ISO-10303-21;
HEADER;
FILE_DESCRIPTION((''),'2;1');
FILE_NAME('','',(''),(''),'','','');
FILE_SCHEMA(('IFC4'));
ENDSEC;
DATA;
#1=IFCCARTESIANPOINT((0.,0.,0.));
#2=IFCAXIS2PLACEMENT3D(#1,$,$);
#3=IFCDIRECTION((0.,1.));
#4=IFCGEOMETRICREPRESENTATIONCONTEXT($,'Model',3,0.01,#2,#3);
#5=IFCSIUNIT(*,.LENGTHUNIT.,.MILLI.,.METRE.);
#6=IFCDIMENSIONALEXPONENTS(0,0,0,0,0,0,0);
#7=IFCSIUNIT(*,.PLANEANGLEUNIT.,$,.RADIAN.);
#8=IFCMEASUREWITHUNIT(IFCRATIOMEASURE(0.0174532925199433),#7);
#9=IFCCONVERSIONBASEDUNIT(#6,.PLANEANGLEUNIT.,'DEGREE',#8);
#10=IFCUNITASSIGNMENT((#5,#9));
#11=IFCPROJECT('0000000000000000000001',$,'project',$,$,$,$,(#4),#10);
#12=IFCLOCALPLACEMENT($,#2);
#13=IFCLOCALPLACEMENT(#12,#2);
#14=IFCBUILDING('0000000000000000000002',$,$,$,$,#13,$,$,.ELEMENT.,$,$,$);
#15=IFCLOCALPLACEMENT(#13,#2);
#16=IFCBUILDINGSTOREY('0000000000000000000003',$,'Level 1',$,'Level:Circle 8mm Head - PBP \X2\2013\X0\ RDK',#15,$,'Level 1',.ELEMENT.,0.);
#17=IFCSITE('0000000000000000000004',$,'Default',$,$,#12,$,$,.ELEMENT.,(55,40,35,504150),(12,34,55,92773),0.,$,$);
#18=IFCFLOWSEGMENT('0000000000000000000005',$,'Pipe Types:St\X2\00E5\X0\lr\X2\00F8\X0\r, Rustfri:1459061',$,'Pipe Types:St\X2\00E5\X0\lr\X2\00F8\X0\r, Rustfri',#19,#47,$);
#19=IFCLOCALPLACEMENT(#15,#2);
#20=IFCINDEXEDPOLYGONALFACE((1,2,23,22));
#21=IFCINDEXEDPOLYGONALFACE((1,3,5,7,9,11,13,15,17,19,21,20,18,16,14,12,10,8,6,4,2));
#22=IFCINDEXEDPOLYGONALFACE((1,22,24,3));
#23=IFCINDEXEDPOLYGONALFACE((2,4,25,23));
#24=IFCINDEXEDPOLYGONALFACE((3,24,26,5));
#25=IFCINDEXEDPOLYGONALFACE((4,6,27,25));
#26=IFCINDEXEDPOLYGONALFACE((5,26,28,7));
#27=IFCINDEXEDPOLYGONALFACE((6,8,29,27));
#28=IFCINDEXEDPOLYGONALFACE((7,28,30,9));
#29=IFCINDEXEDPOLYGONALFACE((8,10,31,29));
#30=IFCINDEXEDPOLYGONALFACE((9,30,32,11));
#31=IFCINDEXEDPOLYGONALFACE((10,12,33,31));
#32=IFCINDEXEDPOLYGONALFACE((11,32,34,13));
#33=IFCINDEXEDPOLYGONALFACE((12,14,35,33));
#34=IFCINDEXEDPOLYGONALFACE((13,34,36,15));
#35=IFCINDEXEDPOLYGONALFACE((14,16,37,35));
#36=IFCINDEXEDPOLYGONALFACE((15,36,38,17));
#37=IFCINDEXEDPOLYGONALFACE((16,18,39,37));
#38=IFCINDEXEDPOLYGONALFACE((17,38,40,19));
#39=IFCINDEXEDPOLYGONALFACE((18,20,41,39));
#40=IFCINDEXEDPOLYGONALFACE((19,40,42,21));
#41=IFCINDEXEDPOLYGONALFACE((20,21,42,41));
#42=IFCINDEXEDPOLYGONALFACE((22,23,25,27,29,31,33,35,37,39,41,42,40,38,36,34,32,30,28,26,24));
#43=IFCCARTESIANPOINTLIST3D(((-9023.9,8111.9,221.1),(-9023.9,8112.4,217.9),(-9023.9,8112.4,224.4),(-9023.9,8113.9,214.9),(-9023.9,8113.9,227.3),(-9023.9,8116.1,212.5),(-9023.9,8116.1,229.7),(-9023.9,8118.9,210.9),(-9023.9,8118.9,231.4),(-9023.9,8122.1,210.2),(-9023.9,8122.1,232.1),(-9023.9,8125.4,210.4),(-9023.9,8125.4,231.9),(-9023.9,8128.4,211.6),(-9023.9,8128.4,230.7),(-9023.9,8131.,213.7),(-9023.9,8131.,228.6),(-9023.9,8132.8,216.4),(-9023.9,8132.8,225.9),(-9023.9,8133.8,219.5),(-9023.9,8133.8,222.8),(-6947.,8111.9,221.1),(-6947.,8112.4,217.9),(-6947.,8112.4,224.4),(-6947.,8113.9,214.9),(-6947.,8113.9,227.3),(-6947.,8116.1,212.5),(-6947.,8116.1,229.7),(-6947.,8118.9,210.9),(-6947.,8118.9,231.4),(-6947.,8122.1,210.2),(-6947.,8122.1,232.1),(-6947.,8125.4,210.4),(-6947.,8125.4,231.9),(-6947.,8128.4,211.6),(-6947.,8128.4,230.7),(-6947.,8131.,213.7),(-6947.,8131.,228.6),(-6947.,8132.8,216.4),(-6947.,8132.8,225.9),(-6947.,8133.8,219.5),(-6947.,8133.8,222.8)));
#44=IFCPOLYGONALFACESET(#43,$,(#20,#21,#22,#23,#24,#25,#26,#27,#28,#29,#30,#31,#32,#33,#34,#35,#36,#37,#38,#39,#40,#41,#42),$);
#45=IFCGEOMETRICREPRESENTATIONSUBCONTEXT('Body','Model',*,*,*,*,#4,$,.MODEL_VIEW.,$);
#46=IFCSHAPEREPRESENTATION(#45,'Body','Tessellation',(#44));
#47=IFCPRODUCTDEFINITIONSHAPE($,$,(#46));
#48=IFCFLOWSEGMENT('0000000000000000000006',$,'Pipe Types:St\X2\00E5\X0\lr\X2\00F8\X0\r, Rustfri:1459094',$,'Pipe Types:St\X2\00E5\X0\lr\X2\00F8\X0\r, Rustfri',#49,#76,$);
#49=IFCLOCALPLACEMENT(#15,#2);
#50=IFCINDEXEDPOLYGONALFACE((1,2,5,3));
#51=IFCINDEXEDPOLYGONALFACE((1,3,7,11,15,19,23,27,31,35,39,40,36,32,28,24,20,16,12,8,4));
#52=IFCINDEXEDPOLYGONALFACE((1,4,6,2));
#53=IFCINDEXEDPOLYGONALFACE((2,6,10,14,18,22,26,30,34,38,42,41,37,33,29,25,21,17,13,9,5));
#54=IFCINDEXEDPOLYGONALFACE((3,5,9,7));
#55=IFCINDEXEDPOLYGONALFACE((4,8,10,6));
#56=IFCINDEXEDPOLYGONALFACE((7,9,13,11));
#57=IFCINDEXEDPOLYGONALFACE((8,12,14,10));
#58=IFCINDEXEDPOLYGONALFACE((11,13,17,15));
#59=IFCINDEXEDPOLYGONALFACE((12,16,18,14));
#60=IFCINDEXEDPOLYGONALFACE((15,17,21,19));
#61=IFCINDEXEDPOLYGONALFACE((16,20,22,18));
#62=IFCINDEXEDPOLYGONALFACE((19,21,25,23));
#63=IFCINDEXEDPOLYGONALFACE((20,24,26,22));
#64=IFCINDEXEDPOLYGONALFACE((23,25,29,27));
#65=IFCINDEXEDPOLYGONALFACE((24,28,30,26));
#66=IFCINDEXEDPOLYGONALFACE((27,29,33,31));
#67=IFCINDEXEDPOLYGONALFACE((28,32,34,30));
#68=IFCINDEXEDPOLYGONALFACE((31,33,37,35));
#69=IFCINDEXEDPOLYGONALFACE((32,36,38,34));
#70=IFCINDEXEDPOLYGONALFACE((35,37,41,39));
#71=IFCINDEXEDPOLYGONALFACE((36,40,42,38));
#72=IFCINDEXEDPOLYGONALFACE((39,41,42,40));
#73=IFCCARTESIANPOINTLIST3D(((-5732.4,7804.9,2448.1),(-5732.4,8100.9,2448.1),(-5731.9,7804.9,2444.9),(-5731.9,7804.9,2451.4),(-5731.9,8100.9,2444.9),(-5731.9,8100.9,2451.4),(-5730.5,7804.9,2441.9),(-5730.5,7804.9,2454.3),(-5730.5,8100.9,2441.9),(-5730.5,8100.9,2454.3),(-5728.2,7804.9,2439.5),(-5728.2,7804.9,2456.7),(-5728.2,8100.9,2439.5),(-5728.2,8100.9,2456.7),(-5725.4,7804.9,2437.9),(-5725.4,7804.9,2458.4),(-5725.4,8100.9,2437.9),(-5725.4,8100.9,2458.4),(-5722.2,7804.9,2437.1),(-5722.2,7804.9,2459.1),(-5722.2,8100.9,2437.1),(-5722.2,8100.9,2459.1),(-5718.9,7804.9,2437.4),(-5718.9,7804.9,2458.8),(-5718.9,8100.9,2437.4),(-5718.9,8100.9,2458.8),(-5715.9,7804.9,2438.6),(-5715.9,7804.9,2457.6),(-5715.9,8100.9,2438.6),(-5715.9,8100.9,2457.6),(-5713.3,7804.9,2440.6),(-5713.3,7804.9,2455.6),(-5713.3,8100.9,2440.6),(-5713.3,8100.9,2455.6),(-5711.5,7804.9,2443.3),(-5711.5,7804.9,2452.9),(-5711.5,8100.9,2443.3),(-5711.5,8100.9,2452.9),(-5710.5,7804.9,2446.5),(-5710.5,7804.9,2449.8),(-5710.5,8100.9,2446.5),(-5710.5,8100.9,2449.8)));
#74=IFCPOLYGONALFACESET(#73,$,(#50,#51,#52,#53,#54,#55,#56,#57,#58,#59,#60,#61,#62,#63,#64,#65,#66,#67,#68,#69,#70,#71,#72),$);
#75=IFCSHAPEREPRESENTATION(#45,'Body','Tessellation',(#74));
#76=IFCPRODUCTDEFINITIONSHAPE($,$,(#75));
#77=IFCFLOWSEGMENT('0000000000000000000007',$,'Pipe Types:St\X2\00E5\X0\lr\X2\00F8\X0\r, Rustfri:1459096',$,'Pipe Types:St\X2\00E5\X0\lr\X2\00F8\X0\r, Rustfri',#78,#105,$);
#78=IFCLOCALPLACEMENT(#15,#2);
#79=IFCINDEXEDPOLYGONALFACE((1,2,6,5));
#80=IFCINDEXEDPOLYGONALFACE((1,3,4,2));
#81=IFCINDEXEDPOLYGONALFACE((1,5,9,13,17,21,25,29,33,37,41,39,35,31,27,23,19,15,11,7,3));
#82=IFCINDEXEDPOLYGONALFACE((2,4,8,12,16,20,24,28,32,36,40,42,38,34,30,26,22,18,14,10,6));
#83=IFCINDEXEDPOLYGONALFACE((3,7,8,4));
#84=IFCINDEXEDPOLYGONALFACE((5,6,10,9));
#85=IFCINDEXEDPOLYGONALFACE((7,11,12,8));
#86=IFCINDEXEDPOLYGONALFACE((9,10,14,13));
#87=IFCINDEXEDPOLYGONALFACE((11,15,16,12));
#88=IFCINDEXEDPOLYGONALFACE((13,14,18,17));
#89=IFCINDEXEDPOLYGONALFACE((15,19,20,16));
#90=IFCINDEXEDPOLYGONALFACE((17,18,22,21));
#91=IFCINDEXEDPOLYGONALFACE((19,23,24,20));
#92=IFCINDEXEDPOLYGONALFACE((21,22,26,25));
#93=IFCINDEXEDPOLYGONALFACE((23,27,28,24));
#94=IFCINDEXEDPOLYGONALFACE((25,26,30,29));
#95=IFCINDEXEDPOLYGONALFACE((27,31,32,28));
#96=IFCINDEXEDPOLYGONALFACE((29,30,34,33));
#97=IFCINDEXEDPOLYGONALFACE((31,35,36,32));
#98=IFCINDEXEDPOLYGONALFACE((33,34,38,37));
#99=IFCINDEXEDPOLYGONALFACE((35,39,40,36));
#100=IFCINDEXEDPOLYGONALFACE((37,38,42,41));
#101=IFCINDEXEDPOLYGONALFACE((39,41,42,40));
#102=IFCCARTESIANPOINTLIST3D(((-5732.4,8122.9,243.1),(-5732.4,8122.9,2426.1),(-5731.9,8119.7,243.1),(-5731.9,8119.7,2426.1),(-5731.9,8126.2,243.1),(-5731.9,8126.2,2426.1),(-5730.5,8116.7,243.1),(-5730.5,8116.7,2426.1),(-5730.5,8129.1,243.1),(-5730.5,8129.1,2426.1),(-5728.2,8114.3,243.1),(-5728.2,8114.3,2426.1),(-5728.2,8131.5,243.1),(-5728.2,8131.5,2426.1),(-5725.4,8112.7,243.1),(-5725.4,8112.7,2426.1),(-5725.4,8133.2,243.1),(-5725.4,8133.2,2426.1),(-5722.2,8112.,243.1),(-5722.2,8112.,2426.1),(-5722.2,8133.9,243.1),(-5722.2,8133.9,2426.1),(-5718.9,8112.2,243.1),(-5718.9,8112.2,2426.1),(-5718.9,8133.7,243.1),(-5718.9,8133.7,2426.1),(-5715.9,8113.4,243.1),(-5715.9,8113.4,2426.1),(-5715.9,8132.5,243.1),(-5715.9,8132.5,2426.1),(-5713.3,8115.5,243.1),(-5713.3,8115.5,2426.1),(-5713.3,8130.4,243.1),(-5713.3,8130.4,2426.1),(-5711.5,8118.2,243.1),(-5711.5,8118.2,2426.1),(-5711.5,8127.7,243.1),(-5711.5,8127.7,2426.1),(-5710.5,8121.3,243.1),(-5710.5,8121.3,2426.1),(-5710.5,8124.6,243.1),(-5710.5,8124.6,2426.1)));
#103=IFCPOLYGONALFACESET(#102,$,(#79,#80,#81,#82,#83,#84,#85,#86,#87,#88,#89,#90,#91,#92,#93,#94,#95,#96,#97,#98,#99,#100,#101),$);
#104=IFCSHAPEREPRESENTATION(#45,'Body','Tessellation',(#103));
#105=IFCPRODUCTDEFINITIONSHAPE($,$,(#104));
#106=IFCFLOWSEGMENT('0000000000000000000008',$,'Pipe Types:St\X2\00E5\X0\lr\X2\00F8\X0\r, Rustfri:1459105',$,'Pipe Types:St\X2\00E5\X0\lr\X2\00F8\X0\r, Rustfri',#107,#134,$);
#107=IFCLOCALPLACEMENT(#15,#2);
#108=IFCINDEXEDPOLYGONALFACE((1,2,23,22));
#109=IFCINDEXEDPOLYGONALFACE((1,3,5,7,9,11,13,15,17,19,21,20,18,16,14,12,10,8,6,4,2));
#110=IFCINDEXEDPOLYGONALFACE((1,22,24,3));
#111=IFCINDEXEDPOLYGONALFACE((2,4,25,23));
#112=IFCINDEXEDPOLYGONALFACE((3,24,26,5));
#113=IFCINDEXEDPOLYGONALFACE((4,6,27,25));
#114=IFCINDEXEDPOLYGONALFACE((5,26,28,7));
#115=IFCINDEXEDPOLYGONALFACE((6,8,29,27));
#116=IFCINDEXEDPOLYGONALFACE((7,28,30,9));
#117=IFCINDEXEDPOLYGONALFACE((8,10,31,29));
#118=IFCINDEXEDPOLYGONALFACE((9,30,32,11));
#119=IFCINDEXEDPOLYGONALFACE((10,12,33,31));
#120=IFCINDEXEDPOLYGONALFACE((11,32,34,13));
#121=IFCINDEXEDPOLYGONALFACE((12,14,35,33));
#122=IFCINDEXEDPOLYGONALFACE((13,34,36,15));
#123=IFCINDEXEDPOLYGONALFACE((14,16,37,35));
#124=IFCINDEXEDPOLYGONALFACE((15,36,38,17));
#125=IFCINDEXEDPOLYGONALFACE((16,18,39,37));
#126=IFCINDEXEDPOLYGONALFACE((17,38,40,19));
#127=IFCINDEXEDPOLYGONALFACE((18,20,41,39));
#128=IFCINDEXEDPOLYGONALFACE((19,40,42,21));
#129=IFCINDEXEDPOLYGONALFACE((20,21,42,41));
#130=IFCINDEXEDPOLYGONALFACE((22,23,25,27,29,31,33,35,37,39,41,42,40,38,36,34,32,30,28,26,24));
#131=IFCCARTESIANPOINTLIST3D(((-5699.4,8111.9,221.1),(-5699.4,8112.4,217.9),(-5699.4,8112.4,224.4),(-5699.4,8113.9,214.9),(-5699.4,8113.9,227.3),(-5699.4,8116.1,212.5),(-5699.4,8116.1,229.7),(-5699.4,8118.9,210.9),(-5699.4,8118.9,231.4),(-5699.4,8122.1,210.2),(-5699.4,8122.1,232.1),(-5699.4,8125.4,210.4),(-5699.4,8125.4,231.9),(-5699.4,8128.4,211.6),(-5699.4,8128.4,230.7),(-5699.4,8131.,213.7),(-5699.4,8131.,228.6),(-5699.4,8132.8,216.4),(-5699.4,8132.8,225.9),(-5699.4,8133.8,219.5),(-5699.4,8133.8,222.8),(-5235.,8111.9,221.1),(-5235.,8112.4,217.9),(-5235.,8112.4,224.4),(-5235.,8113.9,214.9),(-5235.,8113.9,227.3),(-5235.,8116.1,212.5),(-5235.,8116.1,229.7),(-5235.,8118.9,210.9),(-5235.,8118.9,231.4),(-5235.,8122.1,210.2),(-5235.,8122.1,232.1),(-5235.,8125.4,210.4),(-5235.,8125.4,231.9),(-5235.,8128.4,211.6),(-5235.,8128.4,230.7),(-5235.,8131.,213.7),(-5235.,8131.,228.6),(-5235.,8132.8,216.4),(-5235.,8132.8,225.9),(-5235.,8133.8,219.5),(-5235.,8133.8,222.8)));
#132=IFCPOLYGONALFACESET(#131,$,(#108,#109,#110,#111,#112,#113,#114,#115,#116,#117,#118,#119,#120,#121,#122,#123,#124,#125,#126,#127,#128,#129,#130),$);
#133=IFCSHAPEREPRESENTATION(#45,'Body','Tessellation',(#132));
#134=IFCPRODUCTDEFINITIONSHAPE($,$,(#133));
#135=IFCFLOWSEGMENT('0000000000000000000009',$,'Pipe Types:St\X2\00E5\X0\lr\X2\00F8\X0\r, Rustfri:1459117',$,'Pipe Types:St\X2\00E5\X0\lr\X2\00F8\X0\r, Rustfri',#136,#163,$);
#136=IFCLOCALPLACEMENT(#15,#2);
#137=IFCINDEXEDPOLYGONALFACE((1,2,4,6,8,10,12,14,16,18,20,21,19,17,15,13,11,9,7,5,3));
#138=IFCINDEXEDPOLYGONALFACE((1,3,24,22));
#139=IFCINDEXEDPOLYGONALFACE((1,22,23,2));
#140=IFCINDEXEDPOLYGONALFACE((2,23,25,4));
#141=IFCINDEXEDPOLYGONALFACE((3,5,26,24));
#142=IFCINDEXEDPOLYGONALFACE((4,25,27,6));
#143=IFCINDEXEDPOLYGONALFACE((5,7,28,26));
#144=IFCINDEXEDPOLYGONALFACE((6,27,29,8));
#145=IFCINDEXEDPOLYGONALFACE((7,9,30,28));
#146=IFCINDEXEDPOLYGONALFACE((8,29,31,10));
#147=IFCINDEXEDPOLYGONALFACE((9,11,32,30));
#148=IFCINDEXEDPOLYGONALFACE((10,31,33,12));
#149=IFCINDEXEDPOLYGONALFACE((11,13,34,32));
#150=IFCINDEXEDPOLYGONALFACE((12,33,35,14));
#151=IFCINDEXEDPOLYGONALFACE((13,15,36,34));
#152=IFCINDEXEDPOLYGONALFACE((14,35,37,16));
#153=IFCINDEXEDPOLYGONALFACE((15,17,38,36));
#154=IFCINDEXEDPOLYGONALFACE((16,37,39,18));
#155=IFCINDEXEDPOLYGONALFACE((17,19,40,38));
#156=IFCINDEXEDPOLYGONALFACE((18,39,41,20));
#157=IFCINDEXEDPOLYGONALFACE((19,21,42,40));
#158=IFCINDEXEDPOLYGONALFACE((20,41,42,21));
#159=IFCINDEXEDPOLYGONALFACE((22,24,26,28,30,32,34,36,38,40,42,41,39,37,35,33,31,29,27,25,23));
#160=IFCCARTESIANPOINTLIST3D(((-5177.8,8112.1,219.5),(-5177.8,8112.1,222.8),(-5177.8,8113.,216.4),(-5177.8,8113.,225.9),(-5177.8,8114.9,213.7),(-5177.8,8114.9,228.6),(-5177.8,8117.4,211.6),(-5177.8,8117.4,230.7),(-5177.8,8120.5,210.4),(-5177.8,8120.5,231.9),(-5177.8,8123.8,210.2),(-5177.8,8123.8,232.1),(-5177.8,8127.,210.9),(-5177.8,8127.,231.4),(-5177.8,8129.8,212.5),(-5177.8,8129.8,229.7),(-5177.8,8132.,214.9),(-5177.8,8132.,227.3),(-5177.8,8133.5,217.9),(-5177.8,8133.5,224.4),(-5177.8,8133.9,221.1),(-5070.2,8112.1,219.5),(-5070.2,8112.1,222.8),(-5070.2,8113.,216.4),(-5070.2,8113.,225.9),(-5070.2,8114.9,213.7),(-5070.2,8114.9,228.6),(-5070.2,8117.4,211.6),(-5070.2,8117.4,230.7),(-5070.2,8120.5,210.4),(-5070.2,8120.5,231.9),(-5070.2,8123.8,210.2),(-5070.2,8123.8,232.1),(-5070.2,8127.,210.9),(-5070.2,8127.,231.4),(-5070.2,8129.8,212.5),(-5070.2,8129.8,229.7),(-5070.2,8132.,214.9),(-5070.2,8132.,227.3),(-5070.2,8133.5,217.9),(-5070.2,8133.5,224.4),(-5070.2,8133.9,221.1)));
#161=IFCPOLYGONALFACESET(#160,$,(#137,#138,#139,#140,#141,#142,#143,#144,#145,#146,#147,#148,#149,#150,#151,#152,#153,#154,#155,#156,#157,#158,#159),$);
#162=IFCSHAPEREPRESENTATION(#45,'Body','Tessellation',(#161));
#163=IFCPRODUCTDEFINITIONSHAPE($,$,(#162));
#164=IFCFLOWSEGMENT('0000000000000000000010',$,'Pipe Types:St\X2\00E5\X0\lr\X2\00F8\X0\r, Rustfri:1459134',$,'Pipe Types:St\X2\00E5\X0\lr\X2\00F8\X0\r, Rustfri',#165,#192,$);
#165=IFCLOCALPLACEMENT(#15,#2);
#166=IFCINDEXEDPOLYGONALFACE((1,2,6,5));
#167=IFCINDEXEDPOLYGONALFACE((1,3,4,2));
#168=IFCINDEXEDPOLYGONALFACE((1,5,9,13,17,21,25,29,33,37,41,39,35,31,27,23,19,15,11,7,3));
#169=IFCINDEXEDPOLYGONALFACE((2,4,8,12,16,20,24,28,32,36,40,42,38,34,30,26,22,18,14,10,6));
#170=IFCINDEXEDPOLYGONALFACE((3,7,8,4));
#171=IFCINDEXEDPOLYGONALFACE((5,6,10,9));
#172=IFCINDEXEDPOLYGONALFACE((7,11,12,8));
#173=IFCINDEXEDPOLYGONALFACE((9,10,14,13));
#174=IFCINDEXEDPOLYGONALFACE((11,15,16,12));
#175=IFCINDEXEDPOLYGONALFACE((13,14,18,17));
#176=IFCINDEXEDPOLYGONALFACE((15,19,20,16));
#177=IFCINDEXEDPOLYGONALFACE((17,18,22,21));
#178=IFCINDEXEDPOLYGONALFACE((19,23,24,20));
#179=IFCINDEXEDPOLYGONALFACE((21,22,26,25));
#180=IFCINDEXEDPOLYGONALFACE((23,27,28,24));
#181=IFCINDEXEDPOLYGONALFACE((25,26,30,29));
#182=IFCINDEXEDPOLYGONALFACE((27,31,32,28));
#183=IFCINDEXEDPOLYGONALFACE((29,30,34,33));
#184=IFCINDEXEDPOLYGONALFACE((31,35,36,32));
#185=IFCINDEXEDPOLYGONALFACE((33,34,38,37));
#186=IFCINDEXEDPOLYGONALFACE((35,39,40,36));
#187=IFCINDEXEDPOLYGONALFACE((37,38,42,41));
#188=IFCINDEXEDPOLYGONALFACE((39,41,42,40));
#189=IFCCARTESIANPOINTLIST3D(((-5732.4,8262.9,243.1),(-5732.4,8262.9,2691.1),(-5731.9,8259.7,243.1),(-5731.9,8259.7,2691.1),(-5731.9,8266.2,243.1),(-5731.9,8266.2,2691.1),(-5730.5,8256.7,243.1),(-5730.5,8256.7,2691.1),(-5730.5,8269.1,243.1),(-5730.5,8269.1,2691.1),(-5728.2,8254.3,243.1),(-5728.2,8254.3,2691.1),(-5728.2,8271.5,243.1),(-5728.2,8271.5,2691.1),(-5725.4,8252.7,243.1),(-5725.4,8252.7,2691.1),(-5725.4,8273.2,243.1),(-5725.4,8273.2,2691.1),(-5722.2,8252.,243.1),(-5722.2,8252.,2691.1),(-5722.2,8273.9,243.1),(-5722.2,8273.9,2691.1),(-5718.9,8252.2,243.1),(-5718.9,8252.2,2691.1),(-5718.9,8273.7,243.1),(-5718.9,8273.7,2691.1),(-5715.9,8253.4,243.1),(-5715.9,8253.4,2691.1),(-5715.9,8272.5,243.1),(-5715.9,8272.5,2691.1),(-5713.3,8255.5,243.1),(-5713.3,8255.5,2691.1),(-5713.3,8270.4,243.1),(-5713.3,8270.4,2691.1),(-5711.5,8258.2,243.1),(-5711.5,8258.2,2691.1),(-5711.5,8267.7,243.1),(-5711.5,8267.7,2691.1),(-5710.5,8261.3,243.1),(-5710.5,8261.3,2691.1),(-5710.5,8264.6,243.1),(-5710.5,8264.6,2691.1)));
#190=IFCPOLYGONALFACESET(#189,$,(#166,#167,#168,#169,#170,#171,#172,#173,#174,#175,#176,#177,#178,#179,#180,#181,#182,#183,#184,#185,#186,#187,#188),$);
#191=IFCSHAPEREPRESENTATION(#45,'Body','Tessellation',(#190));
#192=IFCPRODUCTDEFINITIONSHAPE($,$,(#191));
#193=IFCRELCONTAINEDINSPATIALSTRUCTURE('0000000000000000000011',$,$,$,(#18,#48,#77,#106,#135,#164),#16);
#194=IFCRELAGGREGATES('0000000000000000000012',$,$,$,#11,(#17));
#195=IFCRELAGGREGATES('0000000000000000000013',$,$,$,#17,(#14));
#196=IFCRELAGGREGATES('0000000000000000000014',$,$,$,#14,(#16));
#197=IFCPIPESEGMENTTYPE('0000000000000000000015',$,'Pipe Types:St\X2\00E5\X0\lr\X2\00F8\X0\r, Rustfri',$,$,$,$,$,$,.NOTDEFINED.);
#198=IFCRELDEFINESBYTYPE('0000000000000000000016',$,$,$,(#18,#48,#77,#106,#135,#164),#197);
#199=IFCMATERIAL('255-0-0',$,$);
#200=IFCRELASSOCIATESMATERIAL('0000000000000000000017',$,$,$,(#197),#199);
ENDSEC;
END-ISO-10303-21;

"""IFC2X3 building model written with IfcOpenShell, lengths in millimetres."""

from ifc_helpers import new_model, entity, si_unit, converted_unit, direction, frame, origin, origin_2d_with_axis, place, context, subcontext, project, spatial, circle, extrude, material, type_object, element, save


model = new_model("IFC2X3")

# Units and contexts
model_context = context("Model", 3, precision=0.01, world=origin(), true_north=direction((0.0, 1.0)))
body_context = subcontext(model_context, "Body", "Model", "MODEL_VIEW")
ifc_project = project(units=[si_unit("LENGTHUNIT", "METRE", prefix="MILLI"), converted_unit("PLANEANGLEUNIT", "DEGREE", entity("IfcRatioMeasure", 0.0174532925199433), si_unit("PLANEANGLEUNIT", "RADIAN"), dimensions=[0, 0, 0, 0, 0, 0, 0])], contexts=[model_context])

# Site, building, storey
site_placement = place(None, origin())
site = spatial("IfcSite", under=ifc_project, at=site_placement, Name="Default", CompositionType="ELEMENT", RefLatitude=(55, 40, 35, 504150), RefLongitude=(12, 34, 55, 92773), RefElevation=0.0)
building_placement = place(site_placement, origin())
building = spatial("IfcBuilding", under=site, at=building_placement, CompositionType="ELEMENT")
storey_placement = place(building_placement, origin())
storey = spatial("IfcBuildingStorey", under=building, at=storey_placement, Name="Level 1", ObjectType="Level:Circle 8mm Head - PBP – RDK", LongName="Level 1", CompositionType="ELEMENT", Elevation=0.0)

# Flow segments
ifc_material = material(Name="255-0-0")
pipe_segment_type = type_object("IfcPipeSegmentType", Name="Pipe Types:Stålrør, Rustfri", PredefinedType="NOTDEFINED", material=ifc_material)
flow_segment_1_placement = place(storey_placement, origin())
element("IfcFlowSegment", 1, at=flow_segment_1_placement, inside=storey, type_object=pipe_segment_type, Name="Pipe Types:Stålrør, Rustfri:1459061", ObjectType="Pipe Types:Stålrør, Rustfri", context=body_context, shape_type="SweptSolid", body=[
    extrude(circle(Radius=11.0, at=origin_2d_with_axis()), frame((-9023.9, 8122.9, 221.1), z_axis=(1.0, 0.0, 0.0), x_axis=(0.0, -1.0, 0.0)), (0.0, 0.0, 1.0), 2076.9),
])
flow_segment_2_placement = place(storey_placement, origin())
element("IfcFlowSegment", 2, at=flow_segment_2_placement, inside=storey, type_object=pipe_segment_type, Name="Pipe Types:Stålrør, Rustfri:1459094", ObjectType="Pipe Types:Stålrør, Rustfri", context=body_context, shape_type="SweptSolid", body=[
    extrude(circle(Radius=11.0, at=origin_2d_with_axis()), frame((-5721.4, 7804.9, 2448.1), z_axis=(0.0, 1.0, 0.0), x_axis=(-1.0, 0.0, 0.0)), (0.0, 0.0, 1.0), 296.0),
])
flow_segment_3_placement = place(storey_placement, origin())
element("IfcFlowSegment", 3, at=flow_segment_3_placement, inside=storey, type_object=pipe_segment_type, Name="Pipe Types:Stålrør, Rustfri:1459096", ObjectType="Pipe Types:Stålrør, Rustfri", context=body_context, shape_type="SweptSolid", body=[
    extrude(circle(Radius=11.0, at=origin_2d_with_axis()), frame((-5721.4, 8122.9, 243.1), z_axis=(0.0, 0.0, 1.0), x_axis=(-1.0, 0.0, 0.0)), (0.0, 0.0, 1.0), 2183.0),
])
flow_segment_4_placement = place(storey_placement, origin())
element("IfcFlowSegment", 4, at=flow_segment_4_placement, inside=storey, type_object=pipe_segment_type, Name="Pipe Types:Stålrør, Rustfri:1459105", ObjectType="Pipe Types:Stålrør, Rustfri", context=body_context, shape_type="SweptSolid", body=[
    extrude(circle(Radius=11.0, at=origin_2d_with_axis()), frame((-5699.4, 8122.9, 221.1), z_axis=(1.0, 0.0, 0.0), x_axis=(0.0, -1.0, 0.0)), (0.0, 0.0, 1.0), 464.4),
])
flow_segment_5_placement = place(storey_placement, origin())
element("IfcFlowSegment", 5, at=flow_segment_5_placement, inside=storey, type_object=pipe_segment_type, Name="Pipe Types:Stålrør, Rustfri:1459117", ObjectType="Pipe Types:Stålrør, Rustfri", context=body_context, shape_type="SweptSolid", body=[
    extrude(circle(Radius=11.0, at=origin_2d_with_axis()), frame((-5177.8, 8122.9, 221.1), z_axis=(1.0, 0.0, 0.0), x_axis=(0.0, 1.0, 0.0)), (0.0, 0.0, 1.0), 107.6),
])
flow_segment_6_placement = place(storey_placement, origin())
element("IfcFlowSegment", 6, at=flow_segment_6_placement, inside=storey, type_object=pipe_segment_type, Name="Pipe Types:Stålrør, Rustfri:1459134", ObjectType="Pipe Types:Stålrør, Rustfri", context=body_context, shape_type="SweptSolid", body=[
    extrude(circle(Radius=11.0, at=origin_2d_with_axis()), frame((-5721.4, 8262.9, 243.1), z_axis=(0.0, 0.0, 1.0), x_axis=(-1.0, 0.0, 0.0)), (0.0, 0.0, 1.0), 2448.0),
])

save(model, "model.ifc")
